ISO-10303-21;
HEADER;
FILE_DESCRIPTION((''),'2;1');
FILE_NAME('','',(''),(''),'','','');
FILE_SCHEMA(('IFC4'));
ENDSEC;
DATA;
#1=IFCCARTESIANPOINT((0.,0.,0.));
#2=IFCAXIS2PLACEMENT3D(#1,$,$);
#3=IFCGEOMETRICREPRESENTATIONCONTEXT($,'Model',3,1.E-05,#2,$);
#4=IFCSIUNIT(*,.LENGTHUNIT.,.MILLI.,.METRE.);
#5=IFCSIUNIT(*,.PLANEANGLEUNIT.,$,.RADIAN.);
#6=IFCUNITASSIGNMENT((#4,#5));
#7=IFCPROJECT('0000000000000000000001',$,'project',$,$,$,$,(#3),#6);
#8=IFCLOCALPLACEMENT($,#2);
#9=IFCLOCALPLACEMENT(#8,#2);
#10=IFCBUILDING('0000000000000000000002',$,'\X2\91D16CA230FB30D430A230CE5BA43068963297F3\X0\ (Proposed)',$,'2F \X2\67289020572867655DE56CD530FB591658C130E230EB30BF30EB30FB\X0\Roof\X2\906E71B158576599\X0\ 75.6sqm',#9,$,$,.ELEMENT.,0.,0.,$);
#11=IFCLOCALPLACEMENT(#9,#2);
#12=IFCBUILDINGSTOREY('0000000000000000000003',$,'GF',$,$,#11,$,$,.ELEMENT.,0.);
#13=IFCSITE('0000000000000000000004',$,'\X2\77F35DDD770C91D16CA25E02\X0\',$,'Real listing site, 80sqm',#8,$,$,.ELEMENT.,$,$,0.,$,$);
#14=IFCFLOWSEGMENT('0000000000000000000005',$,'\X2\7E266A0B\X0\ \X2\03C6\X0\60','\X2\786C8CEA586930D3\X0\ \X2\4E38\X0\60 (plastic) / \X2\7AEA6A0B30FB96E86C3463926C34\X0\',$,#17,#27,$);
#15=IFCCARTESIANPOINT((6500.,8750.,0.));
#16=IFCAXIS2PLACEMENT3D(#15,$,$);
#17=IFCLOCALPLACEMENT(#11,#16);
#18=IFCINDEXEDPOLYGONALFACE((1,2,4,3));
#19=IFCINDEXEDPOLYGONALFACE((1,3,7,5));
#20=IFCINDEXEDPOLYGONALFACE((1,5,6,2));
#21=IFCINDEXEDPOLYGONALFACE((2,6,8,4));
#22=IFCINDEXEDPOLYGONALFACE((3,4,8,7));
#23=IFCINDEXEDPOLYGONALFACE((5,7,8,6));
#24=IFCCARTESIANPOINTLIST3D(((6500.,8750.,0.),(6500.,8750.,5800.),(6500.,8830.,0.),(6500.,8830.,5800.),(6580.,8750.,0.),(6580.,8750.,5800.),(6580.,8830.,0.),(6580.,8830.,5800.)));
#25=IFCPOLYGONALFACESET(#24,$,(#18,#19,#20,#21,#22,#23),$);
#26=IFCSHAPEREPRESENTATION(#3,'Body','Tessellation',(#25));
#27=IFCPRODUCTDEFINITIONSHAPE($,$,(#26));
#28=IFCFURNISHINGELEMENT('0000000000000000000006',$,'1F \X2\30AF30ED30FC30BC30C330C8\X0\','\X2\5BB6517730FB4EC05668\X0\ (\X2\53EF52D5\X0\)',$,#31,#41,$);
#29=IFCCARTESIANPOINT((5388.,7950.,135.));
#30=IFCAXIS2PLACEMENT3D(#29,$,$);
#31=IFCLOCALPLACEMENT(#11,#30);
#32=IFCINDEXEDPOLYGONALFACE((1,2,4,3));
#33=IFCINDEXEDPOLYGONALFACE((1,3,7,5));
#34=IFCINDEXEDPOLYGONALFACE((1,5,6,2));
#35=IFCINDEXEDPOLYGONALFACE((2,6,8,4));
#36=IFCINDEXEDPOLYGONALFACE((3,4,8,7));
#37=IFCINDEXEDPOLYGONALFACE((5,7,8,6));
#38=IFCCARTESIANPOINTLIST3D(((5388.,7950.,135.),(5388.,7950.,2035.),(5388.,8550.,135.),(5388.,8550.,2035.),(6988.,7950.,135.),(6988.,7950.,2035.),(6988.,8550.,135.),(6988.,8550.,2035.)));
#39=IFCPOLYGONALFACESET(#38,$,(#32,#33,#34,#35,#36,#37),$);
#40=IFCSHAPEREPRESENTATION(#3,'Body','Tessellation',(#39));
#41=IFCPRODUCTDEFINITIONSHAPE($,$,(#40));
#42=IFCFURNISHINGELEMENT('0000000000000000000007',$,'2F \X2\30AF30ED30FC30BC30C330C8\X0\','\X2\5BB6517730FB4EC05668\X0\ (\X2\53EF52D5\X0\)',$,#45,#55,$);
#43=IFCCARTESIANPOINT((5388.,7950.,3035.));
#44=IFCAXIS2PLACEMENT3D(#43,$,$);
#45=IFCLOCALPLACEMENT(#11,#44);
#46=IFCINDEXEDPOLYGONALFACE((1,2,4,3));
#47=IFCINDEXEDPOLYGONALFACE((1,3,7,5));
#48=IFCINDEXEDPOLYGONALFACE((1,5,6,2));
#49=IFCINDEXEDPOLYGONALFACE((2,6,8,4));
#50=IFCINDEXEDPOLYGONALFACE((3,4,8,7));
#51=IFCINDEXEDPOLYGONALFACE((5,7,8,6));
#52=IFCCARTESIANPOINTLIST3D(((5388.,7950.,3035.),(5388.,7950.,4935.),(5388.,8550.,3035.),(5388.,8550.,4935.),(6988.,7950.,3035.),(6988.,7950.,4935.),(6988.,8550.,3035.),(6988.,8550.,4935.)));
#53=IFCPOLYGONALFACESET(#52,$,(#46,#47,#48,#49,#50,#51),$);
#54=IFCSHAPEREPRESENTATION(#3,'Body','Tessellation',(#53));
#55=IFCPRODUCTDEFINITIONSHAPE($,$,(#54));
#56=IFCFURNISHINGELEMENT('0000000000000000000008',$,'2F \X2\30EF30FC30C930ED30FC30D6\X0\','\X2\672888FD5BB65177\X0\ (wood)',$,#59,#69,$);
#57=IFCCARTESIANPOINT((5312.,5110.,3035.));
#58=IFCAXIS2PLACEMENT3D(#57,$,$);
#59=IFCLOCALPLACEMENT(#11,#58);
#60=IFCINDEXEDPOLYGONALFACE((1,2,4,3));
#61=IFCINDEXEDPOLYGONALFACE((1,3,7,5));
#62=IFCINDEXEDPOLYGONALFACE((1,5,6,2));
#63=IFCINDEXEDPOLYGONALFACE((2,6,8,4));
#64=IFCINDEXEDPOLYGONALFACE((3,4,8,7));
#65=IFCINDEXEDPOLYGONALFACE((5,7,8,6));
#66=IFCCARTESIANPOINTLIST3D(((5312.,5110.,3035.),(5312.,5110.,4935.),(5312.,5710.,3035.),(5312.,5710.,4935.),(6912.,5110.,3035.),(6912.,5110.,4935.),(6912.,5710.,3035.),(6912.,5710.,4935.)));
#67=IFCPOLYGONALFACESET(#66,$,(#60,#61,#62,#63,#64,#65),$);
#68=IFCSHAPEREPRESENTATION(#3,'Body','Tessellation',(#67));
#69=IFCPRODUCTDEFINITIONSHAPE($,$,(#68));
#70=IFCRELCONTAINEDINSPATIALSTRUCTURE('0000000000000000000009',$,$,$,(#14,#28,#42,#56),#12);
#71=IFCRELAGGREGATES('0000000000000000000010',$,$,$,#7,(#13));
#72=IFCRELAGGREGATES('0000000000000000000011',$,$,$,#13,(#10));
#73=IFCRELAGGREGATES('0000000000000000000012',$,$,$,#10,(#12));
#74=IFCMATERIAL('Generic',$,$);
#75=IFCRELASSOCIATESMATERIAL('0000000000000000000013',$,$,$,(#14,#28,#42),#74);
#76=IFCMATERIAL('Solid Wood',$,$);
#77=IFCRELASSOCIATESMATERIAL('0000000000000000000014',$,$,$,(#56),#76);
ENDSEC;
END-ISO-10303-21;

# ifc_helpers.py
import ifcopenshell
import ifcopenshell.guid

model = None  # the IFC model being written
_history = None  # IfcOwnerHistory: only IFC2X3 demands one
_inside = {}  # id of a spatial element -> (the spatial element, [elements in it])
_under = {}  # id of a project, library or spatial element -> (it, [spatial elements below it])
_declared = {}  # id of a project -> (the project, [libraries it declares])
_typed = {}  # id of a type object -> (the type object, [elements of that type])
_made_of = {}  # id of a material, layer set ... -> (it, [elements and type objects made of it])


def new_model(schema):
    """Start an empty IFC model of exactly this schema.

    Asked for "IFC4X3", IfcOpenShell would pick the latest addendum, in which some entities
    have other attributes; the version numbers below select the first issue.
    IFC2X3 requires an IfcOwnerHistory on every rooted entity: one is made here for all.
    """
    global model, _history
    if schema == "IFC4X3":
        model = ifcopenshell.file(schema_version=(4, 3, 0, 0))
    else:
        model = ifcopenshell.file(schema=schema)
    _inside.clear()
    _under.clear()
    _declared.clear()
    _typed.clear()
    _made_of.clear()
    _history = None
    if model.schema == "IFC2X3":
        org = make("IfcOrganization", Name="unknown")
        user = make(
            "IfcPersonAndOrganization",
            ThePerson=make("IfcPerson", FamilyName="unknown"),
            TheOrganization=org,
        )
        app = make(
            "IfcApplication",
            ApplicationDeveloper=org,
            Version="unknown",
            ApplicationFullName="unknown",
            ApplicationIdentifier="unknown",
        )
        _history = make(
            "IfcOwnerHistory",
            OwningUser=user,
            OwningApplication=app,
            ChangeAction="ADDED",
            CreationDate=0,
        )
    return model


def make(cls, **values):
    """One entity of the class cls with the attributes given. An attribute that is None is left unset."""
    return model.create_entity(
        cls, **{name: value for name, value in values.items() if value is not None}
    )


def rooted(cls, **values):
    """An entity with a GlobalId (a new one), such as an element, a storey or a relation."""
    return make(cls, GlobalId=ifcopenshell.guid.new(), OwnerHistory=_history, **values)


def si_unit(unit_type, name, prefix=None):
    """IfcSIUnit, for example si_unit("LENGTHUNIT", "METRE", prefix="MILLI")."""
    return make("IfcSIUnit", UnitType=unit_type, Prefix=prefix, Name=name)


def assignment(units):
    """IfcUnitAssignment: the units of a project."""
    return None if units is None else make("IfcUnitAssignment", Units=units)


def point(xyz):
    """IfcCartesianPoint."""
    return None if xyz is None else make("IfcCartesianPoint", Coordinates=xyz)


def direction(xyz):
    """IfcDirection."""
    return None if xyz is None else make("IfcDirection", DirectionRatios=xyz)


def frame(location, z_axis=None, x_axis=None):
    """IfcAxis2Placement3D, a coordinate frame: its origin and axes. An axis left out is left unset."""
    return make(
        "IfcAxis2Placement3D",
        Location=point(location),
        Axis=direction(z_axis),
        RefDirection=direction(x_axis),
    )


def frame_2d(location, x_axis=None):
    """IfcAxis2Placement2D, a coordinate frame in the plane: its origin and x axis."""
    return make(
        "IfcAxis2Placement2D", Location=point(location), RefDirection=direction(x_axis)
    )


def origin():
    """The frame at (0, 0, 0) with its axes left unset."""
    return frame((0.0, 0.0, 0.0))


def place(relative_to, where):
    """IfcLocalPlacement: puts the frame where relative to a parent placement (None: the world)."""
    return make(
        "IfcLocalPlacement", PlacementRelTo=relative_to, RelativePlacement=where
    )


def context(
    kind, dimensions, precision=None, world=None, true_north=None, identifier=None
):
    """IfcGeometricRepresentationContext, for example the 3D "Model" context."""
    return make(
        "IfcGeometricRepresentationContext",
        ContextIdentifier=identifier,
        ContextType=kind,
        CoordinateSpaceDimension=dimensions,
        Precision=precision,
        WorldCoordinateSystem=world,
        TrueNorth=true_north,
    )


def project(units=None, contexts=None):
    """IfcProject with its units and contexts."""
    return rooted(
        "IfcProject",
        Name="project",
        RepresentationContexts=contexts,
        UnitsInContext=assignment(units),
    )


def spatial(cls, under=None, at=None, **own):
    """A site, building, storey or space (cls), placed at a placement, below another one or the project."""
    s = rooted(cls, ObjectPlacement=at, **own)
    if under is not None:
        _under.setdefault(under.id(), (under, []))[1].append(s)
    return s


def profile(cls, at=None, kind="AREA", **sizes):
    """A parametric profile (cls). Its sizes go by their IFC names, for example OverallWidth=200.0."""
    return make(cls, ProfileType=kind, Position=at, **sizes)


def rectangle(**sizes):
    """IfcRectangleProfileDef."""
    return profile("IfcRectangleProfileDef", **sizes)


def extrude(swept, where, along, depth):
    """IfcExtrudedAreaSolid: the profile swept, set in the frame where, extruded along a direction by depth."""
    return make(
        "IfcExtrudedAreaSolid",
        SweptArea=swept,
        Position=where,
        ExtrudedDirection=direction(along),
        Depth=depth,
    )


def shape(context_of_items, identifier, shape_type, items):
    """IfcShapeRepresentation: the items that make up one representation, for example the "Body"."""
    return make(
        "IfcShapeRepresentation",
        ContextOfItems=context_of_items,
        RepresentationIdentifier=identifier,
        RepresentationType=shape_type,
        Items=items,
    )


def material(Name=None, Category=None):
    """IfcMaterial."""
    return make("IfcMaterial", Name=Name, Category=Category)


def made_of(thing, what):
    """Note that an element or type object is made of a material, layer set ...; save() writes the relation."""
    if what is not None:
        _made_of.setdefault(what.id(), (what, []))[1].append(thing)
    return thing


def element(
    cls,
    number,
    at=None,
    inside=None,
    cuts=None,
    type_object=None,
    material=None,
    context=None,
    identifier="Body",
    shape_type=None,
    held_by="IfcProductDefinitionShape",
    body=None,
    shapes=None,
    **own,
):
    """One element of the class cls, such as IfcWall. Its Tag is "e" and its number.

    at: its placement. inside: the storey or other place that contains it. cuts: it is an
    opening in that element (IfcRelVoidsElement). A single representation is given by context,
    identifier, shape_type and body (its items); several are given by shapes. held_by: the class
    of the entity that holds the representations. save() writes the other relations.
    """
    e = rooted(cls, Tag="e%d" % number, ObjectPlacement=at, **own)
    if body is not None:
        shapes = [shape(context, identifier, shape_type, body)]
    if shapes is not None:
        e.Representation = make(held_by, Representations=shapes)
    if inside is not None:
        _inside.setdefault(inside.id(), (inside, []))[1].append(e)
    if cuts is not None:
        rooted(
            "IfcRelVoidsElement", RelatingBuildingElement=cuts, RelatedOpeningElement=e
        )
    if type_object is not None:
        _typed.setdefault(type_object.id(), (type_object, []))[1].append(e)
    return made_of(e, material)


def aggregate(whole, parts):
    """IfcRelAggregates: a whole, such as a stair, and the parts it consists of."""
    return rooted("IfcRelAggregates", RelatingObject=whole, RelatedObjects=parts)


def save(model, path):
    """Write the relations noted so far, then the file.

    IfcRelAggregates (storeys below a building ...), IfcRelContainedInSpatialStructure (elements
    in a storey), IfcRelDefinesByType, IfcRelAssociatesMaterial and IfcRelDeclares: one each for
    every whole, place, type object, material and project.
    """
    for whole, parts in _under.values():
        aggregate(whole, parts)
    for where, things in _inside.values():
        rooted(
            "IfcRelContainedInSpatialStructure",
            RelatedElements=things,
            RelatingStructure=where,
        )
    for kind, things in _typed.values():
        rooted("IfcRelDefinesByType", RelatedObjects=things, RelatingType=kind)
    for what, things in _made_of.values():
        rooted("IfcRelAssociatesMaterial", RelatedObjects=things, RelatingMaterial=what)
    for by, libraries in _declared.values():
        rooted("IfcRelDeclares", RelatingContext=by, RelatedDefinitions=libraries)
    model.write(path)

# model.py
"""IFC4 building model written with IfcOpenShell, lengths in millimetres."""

from ifc_helpers import new_model, si_unit, frame, frame_2d, origin, place, context, project, spatial, rectangle, extrude, material, element, save


model = new_model("IFC4")

# Units and contexts
model_context = context("Model", 3, precision=1e-05, world=origin())
ifc_project = project(units=[si_unit("LENGTHUNIT", "METRE", prefix="MILLI"), si_unit("PLANEANGLEUNIT", "RADIAN")], contexts=[model_context])

# Site, building, storey
site_placement = place(None, origin())
site = spatial("IfcSite", under=ifc_project, at=site_placement, Name="石川県金沢市", ObjectType="Real listing site, 80sqm", CompositionType="ELEMENT", RefElevation=0.0)
building_placement = place(site_placement, origin())
building = spatial("IfcBuilding", under=site, at=building_placement, Name="金沢・ピアノ室と防音 (Proposed)", ObjectType="2F 木造在来工法・外壁モルタル・Roof遮熱塗料 75.6sqm", CompositionType="ELEMENT", ElevationOfRefHeight=0.0, ElevationOfTerrain=0.0)
storey_placement = place(building_placement, origin())
storey = spatial("IfcBuildingStorey", under=building, at=storey_placement, Name="GF", CompositionType="ELEMENT", Elevation=0.0)

# Shared definitions
ifc_material_1 = material(Name="Solid Wood")

# Shared definitions
ifc_material_2 = material(Name="Generic")

# Flow segment
flow_segment_placement = place(storey_placement, frame((6500.0, 8750.0, 0.0)))
element("IfcFlowSegment", 1, at=flow_segment_placement, inside=storey, material=ifc_material_2, Name="縦樋 φ60", Description="硬質塩ビ 丸60 (plastic) / 竪樋・雨水排水", context=model_context, shape_type="SweptSolid", body=[
    extrude(rectangle(XDim=80.0, YDim=80.0, at=frame_2d((40.0, 40.0))), frame((6500.0, 8750.0, 0.0)), (0.0, 0.0, 1.0), 5800.0),
])

# Furnishing elements
furnishing_1_placement = place(storey_placement, frame((5388.0, 7950.0, 135.0)))
element("IfcFurnishingElement", 2, at=furnishing_1_placement, inside=storey, material=ifc_material_2, Name="1F クローゼット", Description="家具・什器 (可動)", context=model_context, shape_type="SweptSolid", body=[
    extrude(rectangle(XDim=1600.0, YDim=600.0, at=frame_2d((800.0, 300.0))), frame((5388.0, 7950.0, 135.0)), (0.0, 0.0, 1.0), 1900.0),
])
furnishing_2_placement = place(storey_placement, frame((5388.0, 7950.0, 3035.0)))
element("IfcFurnishingElement", 3, at=furnishing_2_placement, inside=storey, material=ifc_material_2, Name="2F クローゼット", Description="家具・什器 (可動)", context=model_context, shape_type="SweptSolid", body=[
    extrude(rectangle(XDim=1600.0, YDim=600.0, at=frame_2d((800.0, 300.0))), frame((5388.0, 7950.0, 3035.0)), (0.0, 0.0, 1.0), 1900.0),
])
furnishing_3_placement = place(storey_placement, frame((5312.0, 5110.0, 3035.0)))
element("IfcFurnishingElement", 4, at=furnishing_3_placement, inside=storey, material=ifc_material_1, Name="2F ワードローブ", Description="木製家具 (wood)", context=model_context, shape_type="SweptSolid", body=[
    extrude(rectangle(XDim=1600.0, YDim=600.0, at=frame_2d((800.0, 300.0))), frame((5312.0, 5110.0, 3035.0)), (0.0, 0.0, 1.0), 1900.0),
])

save(model, "model.ifc")
